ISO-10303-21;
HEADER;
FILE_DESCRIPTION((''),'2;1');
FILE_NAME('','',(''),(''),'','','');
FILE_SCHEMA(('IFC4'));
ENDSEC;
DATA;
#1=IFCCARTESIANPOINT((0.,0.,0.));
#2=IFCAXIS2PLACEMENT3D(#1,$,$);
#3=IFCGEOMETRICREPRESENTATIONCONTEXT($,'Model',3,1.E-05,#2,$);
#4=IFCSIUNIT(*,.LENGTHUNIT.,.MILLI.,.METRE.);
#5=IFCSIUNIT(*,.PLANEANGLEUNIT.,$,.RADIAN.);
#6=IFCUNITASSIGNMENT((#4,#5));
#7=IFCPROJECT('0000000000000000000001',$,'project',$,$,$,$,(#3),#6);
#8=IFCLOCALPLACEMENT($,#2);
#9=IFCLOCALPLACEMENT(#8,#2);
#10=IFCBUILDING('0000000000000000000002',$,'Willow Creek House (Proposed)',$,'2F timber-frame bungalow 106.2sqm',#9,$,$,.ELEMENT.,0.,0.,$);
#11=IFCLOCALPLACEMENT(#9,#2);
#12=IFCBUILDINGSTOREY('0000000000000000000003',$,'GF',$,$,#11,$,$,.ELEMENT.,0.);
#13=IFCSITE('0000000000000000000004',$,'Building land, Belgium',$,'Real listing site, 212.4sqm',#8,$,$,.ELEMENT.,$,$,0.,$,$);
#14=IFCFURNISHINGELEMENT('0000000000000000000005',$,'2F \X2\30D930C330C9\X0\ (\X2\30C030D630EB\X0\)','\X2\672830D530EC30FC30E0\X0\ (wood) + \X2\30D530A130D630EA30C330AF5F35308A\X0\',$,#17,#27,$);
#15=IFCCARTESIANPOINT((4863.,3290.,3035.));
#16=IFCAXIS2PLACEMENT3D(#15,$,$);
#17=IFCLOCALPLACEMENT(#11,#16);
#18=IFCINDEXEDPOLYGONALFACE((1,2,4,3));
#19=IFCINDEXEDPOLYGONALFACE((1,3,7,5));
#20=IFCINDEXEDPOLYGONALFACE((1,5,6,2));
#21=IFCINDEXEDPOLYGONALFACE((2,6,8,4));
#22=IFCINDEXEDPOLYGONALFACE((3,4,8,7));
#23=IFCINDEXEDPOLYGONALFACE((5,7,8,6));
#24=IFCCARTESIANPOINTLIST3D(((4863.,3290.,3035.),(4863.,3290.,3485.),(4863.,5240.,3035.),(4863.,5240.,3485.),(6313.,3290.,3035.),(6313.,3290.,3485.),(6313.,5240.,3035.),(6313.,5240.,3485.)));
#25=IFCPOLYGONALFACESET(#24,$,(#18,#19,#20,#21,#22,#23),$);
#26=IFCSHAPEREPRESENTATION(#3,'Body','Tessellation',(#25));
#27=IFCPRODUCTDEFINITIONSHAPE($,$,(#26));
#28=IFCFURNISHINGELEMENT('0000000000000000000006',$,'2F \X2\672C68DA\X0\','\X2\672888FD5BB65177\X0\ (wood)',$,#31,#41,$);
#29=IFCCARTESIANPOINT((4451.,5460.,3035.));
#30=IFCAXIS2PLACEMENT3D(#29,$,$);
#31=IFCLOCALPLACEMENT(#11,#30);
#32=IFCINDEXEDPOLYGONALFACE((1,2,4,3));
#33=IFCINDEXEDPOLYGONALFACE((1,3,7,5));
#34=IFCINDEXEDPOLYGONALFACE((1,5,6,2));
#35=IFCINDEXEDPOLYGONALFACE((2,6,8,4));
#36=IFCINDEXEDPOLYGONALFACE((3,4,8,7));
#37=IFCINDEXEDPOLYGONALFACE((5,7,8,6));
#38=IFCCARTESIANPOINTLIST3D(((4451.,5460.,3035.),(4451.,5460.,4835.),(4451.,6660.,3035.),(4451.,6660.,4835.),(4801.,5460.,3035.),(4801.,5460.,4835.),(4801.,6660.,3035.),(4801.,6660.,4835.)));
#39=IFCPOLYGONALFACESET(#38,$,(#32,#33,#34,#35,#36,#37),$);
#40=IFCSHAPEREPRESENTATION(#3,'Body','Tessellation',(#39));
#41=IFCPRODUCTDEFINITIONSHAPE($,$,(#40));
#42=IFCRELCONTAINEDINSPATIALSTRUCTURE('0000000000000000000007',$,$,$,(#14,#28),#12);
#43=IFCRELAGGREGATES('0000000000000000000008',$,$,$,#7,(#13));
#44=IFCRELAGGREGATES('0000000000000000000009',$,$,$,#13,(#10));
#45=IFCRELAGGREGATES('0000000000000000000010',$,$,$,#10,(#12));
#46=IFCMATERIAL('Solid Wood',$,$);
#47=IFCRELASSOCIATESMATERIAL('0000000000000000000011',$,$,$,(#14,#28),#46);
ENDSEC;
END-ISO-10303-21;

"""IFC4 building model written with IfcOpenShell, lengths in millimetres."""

from ifc_helpers import new_model, si_unit, frame, frame_2d, origin, place, context, project, spatial, rectangle, extrude, material, element, save


model = new_model("IFC4")

# Units and contexts
model_context = context("Model", 3, precision=1e-05, world=origin())
ifc_project = project(units=[si_unit("LENGTHUNIT", "METRE", prefix="MILLI"), si_unit("PLANEANGLEUNIT", "RADIAN")], contexts=[model_context])

# Site, building, storey
site_placement = place(None, origin())
site = spatial("IfcSite", under=ifc_project, at=site_placement, Name="Building land, Belgium", ObjectType="Real listing site, 212.4sqm", CompositionType="ELEMENT", RefElevation=0.0)
building_placement = place(site_placement, origin())
building = spatial("IfcBuilding", under=site, at=building_placement, Name="Willow Creek House (Proposed)", ObjectType="2F timber-frame bungalow 106.2sqm", CompositionType="ELEMENT", ElevationOfRefHeight=0.0, ElevationOfTerrain=0.0)
storey_placement = place(building_placement, origin())
storey = spatial("IfcBuildingStorey", under=building, at=storey_placement, Name="GF", CompositionType="ELEMENT", Elevation=0.0)

# Shared definitions
ifc_material_1 = material(Name="Solid Wood")

# Furnishing elements
furnishing_1_placement = place(storey_placement, frame((4863.0, 3290.0, 3035.0)))
element("IfcFurnishingElement", 1, at=furnishing_1_placement, inside=storey, material=ifc_material_1, Name="2F ベッド (ダブル)", Description="木フレーム (wood) + ファブリック張り", context=model_context, shape_type="SweptSolid", body=[
    extrude(rectangle(XDim=1450.0, YDim=1950.0, at=frame_2d((725.0, 975.0))), frame((4863.0, 3290.0, 3035.0)), (0.0, 0.0, 1.0), 450.0),
])
furnishing_2_placement = place(storey_placement, frame((4451.0, 5460.0, 3035.0)))
element("IfcFurnishingElement", 2, at=furnishing_2_placement, inside=storey, material=ifc_material_1, Name="2F 本棚", Description="木製家具 (wood)", context=model_context, shape_type="SweptSolid", body=[
    extrude(rectangle(XDim=350.0, YDim=1200.0, at=frame_2d((175.0, 600.0))), frame((4451.0, 5460.0, 3035.0)), (0.0, 0.0, 1.0), 1800.0),
])

save(model, "model.ifc")
